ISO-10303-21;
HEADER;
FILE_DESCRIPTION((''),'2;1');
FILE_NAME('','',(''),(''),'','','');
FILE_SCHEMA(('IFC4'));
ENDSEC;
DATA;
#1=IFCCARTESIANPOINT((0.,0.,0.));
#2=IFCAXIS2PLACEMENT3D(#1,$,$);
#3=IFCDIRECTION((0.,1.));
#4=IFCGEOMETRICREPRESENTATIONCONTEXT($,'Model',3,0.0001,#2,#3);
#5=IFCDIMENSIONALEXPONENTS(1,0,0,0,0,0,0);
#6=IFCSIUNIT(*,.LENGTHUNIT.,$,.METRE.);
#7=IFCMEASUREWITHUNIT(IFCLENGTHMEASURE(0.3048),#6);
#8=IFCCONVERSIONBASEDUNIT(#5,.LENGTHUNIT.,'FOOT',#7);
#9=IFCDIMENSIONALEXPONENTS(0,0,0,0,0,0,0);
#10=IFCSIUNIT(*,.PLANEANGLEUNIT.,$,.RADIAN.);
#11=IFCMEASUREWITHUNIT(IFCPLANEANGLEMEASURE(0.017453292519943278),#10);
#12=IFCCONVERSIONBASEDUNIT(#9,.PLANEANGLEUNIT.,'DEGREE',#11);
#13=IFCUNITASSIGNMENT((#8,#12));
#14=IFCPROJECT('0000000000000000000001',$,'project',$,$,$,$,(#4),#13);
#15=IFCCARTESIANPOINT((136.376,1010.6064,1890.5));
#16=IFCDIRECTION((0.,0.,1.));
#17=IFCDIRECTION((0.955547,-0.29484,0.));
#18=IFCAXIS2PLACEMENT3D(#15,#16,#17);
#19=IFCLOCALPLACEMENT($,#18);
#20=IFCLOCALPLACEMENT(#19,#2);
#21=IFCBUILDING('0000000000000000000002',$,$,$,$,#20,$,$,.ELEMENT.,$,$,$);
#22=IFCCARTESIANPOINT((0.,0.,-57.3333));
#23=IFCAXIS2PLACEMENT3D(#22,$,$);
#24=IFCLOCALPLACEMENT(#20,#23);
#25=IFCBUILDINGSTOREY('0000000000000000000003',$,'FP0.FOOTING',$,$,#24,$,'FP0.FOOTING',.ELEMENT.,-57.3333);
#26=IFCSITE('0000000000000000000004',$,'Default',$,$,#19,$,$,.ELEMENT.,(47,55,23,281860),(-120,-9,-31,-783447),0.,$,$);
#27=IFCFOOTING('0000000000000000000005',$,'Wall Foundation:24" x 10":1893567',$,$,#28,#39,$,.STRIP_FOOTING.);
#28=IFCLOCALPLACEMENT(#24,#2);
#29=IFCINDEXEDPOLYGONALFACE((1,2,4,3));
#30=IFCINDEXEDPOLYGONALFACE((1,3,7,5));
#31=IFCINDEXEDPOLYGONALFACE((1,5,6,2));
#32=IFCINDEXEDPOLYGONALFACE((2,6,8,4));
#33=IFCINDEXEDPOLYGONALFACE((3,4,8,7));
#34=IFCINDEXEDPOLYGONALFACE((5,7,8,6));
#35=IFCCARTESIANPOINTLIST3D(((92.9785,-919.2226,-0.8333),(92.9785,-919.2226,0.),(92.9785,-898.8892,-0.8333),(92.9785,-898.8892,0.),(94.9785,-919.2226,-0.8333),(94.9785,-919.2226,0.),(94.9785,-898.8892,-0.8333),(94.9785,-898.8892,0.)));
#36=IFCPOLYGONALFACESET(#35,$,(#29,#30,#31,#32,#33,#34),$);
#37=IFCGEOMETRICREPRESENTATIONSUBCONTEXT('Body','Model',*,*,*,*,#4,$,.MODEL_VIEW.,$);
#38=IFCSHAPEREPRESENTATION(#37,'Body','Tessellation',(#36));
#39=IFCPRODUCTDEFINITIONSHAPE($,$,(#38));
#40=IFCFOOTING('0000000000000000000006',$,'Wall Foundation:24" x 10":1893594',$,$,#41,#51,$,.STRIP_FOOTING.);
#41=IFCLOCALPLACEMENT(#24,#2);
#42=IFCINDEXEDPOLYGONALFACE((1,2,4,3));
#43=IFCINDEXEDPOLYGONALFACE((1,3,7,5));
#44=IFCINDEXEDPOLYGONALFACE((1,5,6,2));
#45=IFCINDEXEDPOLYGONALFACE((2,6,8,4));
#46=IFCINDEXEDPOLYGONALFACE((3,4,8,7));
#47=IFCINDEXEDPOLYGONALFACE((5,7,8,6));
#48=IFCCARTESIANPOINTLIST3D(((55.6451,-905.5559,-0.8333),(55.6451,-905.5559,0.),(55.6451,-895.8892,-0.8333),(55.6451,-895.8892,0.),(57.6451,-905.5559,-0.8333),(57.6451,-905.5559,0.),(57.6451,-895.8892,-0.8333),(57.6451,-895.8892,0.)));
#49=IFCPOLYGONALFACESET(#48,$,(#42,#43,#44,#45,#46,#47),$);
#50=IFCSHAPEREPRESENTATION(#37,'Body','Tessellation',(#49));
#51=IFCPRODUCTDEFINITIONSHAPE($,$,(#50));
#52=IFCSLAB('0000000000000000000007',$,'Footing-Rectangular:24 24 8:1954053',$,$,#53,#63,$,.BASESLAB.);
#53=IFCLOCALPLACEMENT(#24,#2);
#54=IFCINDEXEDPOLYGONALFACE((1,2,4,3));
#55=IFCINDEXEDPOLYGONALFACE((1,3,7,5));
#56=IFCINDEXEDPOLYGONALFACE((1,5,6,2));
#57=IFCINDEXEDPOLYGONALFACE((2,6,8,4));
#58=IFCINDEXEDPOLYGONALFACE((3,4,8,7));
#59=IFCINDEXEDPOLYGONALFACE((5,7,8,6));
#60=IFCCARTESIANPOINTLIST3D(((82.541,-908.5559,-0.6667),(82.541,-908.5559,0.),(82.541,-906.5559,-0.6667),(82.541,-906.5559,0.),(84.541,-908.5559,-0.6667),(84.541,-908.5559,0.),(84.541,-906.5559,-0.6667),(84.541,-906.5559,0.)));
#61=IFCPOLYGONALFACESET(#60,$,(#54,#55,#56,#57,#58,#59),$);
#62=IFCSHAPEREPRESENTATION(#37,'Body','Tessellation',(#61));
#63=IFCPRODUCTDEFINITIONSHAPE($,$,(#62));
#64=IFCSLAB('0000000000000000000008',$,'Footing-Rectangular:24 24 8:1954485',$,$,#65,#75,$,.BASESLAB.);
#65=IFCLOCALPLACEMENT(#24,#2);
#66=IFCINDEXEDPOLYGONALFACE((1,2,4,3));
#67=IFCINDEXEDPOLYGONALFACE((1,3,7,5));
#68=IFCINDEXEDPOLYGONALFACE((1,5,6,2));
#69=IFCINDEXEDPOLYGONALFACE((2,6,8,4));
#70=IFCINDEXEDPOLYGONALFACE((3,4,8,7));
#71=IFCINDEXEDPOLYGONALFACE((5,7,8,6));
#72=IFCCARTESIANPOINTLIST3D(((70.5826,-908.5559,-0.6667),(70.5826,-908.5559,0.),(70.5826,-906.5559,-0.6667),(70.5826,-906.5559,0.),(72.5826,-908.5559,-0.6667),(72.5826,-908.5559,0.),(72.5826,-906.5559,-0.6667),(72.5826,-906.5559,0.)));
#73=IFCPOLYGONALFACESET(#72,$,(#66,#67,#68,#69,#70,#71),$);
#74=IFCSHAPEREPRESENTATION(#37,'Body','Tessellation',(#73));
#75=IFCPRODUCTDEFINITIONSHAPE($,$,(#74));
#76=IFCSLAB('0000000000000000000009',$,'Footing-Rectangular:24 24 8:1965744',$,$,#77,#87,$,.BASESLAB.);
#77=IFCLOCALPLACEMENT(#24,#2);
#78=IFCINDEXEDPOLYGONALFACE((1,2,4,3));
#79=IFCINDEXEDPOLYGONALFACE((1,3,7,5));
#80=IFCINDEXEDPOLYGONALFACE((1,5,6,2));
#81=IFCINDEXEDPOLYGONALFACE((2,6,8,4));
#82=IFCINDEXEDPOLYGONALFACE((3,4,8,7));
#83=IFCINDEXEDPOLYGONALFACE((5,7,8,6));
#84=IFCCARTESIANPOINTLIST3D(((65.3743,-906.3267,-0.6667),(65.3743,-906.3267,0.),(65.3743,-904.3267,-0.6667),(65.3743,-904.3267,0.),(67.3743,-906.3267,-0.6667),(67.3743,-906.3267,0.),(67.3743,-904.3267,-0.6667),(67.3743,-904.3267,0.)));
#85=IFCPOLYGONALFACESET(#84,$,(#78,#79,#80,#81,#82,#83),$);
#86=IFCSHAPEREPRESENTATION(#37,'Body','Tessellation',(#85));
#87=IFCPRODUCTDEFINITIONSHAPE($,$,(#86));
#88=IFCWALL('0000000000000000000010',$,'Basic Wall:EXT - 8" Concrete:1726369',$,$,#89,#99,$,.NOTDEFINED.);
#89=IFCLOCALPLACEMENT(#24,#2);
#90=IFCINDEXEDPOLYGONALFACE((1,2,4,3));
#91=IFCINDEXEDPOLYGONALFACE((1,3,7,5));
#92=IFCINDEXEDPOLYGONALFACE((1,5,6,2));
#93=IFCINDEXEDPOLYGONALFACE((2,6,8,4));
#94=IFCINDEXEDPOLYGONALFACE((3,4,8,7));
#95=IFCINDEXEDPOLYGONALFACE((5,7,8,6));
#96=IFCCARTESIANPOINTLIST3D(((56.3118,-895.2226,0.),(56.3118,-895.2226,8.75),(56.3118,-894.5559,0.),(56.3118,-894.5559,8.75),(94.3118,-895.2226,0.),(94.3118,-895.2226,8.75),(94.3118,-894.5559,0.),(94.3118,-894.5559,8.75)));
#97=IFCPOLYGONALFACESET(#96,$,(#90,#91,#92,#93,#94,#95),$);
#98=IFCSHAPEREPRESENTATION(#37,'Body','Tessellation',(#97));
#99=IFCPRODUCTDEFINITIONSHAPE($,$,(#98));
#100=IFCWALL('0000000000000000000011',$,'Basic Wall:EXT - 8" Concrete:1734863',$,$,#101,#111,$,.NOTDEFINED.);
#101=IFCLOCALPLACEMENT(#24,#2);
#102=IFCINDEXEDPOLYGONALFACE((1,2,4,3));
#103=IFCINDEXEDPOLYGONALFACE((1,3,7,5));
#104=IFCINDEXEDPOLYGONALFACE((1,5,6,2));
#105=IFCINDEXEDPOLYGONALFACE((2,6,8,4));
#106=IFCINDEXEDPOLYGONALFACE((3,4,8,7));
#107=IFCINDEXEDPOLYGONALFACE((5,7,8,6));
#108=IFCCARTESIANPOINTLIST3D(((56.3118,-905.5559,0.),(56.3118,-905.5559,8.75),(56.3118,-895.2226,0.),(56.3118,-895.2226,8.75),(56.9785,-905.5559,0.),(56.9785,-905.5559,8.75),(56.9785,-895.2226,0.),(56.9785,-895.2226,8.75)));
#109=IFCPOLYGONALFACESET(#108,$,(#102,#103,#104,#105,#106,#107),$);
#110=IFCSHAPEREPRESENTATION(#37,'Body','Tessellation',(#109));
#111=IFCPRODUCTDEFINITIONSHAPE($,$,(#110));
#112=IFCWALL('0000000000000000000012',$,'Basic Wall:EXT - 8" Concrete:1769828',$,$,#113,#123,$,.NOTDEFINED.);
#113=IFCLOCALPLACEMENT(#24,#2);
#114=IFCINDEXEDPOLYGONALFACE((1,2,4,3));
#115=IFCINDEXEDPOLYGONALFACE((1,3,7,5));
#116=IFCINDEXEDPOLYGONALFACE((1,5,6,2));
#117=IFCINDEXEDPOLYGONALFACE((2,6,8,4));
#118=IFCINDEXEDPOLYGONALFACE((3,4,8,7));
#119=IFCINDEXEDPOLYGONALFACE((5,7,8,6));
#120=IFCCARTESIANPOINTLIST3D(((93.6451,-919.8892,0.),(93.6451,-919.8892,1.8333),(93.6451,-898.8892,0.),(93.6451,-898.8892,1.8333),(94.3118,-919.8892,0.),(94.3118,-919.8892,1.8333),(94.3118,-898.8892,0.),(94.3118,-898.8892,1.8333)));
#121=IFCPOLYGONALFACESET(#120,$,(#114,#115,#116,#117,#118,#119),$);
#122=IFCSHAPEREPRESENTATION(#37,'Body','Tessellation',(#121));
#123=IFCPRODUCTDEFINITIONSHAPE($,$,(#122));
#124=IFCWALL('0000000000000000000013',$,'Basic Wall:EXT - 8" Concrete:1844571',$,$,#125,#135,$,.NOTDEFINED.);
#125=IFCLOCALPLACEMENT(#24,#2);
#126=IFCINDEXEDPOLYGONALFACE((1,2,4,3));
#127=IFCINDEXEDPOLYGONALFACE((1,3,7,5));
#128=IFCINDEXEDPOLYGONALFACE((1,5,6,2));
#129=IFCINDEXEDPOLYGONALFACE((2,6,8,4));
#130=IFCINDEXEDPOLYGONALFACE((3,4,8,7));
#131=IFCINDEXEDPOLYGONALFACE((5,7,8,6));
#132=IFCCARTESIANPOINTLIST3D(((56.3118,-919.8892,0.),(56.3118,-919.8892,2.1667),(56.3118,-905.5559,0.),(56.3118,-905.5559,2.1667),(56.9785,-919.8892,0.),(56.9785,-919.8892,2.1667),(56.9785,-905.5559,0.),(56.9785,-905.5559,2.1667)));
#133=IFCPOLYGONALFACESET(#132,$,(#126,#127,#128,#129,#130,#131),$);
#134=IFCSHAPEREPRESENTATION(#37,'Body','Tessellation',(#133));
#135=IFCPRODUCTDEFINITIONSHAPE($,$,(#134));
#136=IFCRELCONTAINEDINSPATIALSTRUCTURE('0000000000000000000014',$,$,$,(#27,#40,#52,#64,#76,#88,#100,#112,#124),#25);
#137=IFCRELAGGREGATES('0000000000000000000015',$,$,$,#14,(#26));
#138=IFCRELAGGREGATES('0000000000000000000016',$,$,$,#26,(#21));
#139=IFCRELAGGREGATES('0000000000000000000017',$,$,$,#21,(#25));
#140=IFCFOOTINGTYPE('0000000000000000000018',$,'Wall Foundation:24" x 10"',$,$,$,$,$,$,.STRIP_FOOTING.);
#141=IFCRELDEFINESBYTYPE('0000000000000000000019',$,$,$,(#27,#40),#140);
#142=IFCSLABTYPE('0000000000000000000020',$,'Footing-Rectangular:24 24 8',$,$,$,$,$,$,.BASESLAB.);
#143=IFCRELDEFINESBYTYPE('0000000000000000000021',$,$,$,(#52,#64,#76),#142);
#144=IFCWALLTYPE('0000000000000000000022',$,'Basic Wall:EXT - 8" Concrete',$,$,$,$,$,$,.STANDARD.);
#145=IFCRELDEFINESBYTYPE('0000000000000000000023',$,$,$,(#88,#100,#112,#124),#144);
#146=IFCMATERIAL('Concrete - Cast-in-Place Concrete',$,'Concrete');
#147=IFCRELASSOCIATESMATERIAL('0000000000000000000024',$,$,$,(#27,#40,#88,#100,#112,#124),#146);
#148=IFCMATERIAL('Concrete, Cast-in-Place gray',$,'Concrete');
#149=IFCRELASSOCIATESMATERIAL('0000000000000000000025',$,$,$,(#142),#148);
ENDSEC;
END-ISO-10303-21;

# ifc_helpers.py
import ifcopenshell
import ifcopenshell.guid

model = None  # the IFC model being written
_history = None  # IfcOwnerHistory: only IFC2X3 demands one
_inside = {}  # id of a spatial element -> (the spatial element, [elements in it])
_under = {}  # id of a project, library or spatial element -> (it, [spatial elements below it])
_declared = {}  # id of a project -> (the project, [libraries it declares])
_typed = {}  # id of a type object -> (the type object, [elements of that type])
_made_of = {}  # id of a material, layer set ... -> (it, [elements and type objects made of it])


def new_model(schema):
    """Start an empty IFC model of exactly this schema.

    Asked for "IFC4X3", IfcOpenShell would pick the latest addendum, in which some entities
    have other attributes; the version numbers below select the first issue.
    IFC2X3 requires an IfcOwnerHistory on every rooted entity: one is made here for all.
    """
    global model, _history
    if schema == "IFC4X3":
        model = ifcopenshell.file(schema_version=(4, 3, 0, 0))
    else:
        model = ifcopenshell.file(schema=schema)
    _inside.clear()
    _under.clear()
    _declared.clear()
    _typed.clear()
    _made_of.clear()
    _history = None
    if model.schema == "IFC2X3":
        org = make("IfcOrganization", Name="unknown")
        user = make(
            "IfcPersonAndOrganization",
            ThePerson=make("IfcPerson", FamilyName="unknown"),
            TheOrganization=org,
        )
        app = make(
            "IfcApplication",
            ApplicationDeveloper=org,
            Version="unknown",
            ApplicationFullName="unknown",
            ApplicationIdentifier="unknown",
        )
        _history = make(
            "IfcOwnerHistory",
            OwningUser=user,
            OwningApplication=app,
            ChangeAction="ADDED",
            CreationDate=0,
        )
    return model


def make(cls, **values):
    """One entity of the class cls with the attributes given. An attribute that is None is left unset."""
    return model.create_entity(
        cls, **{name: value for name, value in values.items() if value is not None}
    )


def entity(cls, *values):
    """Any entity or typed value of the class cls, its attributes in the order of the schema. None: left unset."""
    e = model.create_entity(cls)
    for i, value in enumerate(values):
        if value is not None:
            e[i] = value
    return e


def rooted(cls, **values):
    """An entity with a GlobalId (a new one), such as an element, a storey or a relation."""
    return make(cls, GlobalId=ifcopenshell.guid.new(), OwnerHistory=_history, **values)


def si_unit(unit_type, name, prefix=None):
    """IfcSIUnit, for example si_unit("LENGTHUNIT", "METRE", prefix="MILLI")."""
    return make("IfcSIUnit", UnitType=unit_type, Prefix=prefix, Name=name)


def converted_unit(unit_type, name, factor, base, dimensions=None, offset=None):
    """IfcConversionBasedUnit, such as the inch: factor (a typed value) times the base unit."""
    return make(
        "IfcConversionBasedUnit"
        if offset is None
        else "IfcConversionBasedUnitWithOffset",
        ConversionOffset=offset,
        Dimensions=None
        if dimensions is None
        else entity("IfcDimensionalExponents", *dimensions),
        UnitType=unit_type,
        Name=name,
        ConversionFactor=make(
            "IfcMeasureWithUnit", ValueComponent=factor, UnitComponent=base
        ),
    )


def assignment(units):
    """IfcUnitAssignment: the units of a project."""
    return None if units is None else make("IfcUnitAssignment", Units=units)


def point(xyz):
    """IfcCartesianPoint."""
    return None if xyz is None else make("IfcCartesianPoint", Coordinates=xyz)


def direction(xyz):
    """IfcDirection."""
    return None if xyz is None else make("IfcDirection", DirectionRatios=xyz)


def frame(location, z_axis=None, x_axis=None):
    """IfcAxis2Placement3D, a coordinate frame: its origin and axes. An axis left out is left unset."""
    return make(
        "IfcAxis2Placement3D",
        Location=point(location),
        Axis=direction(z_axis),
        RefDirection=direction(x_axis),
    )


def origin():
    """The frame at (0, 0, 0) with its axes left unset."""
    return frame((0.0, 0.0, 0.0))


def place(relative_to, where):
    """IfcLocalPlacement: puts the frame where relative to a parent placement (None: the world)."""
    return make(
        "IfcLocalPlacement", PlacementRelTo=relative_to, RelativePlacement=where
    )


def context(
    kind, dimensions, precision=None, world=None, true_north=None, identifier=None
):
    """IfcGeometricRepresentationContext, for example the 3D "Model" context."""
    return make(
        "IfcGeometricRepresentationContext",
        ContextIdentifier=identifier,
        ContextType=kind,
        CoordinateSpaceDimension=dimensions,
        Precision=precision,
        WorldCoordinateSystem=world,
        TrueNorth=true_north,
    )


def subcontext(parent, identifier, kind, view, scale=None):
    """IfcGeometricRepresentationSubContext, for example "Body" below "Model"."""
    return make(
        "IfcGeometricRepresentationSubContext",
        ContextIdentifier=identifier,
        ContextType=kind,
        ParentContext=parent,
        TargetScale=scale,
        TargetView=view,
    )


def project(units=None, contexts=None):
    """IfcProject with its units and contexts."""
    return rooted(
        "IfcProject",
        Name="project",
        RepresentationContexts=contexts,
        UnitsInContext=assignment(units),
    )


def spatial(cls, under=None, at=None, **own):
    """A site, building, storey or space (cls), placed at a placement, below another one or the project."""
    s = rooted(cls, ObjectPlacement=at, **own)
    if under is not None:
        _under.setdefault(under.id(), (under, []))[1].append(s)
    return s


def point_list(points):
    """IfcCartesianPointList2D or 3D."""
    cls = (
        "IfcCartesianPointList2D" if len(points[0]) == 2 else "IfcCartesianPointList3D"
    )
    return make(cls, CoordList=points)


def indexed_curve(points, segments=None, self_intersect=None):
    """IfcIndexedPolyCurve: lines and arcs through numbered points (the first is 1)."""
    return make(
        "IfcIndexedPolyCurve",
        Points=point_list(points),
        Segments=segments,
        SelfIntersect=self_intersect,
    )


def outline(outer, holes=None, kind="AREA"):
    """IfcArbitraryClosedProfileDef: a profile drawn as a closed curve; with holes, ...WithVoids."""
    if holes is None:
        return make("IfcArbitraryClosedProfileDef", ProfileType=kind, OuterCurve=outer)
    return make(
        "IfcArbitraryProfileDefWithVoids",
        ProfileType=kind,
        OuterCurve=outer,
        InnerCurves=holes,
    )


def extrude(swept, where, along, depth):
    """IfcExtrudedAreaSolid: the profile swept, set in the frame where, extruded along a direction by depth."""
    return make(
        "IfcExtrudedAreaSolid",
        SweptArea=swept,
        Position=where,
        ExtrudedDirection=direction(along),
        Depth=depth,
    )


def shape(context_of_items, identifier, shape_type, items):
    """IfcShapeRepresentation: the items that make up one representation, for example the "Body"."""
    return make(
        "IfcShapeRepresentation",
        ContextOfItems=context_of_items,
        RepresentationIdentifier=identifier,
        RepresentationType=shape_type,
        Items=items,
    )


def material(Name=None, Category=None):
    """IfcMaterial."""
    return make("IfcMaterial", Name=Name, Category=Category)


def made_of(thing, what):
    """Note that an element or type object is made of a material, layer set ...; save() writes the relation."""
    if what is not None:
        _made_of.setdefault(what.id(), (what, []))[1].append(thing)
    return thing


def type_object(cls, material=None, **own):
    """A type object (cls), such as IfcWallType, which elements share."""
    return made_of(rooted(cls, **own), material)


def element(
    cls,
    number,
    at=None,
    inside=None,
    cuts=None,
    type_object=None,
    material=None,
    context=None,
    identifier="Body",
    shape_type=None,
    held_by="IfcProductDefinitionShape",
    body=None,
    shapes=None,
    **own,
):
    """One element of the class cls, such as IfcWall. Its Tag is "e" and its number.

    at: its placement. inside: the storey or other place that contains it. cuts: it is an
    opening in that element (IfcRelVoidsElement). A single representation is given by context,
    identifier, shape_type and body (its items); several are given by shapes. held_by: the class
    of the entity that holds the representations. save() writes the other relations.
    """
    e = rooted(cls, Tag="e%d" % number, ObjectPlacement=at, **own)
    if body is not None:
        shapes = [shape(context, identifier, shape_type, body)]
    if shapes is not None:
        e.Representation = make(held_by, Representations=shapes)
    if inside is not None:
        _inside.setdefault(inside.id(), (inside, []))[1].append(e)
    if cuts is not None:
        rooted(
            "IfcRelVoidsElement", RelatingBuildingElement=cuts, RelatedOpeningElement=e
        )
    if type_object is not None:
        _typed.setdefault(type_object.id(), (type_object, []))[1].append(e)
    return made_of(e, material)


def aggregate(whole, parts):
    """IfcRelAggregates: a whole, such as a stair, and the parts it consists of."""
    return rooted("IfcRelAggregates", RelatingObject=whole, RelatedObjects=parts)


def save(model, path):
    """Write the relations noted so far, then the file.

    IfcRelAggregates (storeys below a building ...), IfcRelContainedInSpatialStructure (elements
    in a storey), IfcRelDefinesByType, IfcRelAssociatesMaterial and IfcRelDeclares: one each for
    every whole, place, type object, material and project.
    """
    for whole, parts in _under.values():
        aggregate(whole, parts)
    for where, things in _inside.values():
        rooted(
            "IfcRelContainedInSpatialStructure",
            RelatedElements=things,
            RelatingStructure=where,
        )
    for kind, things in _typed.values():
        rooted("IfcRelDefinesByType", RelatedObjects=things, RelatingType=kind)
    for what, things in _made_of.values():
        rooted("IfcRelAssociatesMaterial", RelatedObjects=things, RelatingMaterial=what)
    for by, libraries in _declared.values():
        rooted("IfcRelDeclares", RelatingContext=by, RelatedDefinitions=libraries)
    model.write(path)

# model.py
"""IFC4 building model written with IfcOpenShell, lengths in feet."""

from ifc_helpers import new_model, entity, si_unit, converted_unit, direction, frame, origin, place, context, subcontext, project, spatial, indexed_curve, outline, extrude, material, type_object, element, save


model = new_model("IFC4")

# Units and contexts
model_context = context("Model", 3, precision=0.0001, world=origin(), true_north=direction((0.0, 1.0)))
body_context = subcontext(model_context, "Body", "Model", "MODEL_VIEW")
ifc_project = project(units=[converted_unit("LENGTHUNIT", "FOOT", entity("IfcLengthMeasure", 0.3048), si_unit("LENGTHUNIT", "METRE"), dimensions=[1, 0, 0, 0, 0, 0, 0]), converted_unit("PLANEANGLEUNIT", "DEGREE", entity("IfcPlaneAngleMeasure", 0.017453292519943278), si_unit("PLANEANGLEUNIT", "RADIAN"), dimensions=[0, 0, 0, 0, 0, 0, 0])], contexts=[model_context])

# Site, building, storey
site_placement = place(None, frame((136.376, 1010.6064, 1890.5), z_axis=(0.0, 0.0, 1.0), x_axis=(0.955547, -0.29484, 0.0)))
site = spatial("IfcSite", under=ifc_project, at=site_placement, Name="Default", CompositionType="ELEMENT", RefLatitude=(47, 55, 23, 281860), RefLongitude=(-120, -9, -31, -783447), RefElevation=0.0)
building_placement = place(site_placement, origin())
building = spatial("IfcBuilding", under=site, at=building_placement, CompositionType="ELEMENT")
storey_placement = place(building_placement, frame((0.0, 0.0, -57.3333)))
storey = spatial("IfcBuildingStorey", under=building, at=storey_placement, Name="FP0.FOOTING", LongName="FP0.FOOTING", CompositionType="ELEMENT", Elevation=-57.3333)

# Footings
ifc_material_1 = material(Name="Concrete - Cast-in-Place Concrete", Category="Concrete")
footing_type = type_object("IfcFootingType", Name="Wall Foundation:24\" x 10\"", PredefinedType="STRIP_FOOTING")
footing_1_placement = place(storey_placement, origin())
element("IfcFooting", 1, at=footing_1_placement, inside=storey, type_object=footing_type, material=ifc_material_1, Name="Wall Foundation:24\" x 10\":1893567", PredefinedType="STRIP_FOOTING", context=body_context, shape_type="SweptSolid", body=[
    extrude(outline(indexed_curve([(-10.1667, -1.0), (10.1667, -1.0), (10.1667, 1.0), (-10.1667, 1.0), (-10.1667, -1.0)], self_intersect=False)), frame((93.9785, -909.0559, -0.8333), z_axis=(0.0, 0.0, 1.0), x_axis=(0.0, -1.0, 0.0)), (0.0, 0.0, 1.0), 0.8333),
])
footing_2_placement = place(storey_placement, origin())
element("IfcFooting", 2, at=footing_2_placement, inside=storey, type_object=footing_type, material=ifc_material_1, Name="Wall Foundation:24\" x 10\":1893594", PredefinedType="STRIP_FOOTING", context=body_context, shape_type="SweptSolid", body=[
    extrude(outline(indexed_curve([(-4.8333, -1.0), (4.8333, -1.0), (4.8333, 1.0), (-4.8333, 1.0), (-4.8333, -1.0)], self_intersect=False)), frame((56.6451, -900.7226, -0.8333), z_axis=(0.0, 0.0, 1.0), x_axis=(0.0, 1.0, 0.0)), (0.0, 0.0, 1.0), 0.8333),
])

# Slabs
ifc_material_2 = material(Name="Concrete, Cast-in-Place gray", Category="Concrete")
slab_type = type_object("IfcSlabType", Name="Footing-Rectangular:24 24 8", PredefinedType="BASESLAB", material=ifc_material_2)
slab_1_placement = place(storey_placement, origin())
element("IfcSlab", 3, at=slab_1_placement, inside=storey, type_object=slab_type, Name="Footing-Rectangular:24 24 8:1954053", PredefinedType="BASESLAB", context=body_context, shape_type="SweptSolid", body=[
    extrude(outline(indexed_curve([(-1.0, -1.0), (1.0, -1.0), (1.0, 1.0), (-1.0, 1.0), (-1.0, -1.0)], self_intersect=False)), frame((83.541, -907.5559, -0.6667), z_axis=(0.0, 0.0, 1.0), x_axis=(-1.0, 0.0, 0.0)), (0.0, 0.0, 1.0), 0.6667),
])
slab_2_placement = place(storey_placement, origin())
element("IfcSlab", 4, at=slab_2_placement, inside=storey, type_object=slab_type, Name="Footing-Rectangular:24 24 8:1954485", PredefinedType="BASESLAB", context=body_context, shape_type="SweptSolid", body=[
    extrude(outline(indexed_curve([(-1.0, -1.0), (1.0, -1.0), (1.0, 1.0), (-1.0, 1.0), (-1.0, -1.0)], self_intersect=False)), frame((71.5826, -907.5559, -0.6667), z_axis=(0.0, 0.0, 1.0), x_axis=(-1.0, 0.0, 0.0)), (0.0, 0.0, 1.0), 0.6667),
])
slab_3_placement = place(storey_placement, origin())
element("IfcSlab", 5, at=slab_3_placement, inside=storey, type_object=slab_type, Name="Footing-Rectangular:24 24 8:1965744", PredefinedType="BASESLAB", context=body_context, shape_type="SweptSolid", body=[
    extrude(outline(indexed_curve([(-1.0, -1.0), (1.0, -1.0), (1.0, 1.0), (-1.0, 1.0), (-1.0, -1.0)], self_intersect=False)), frame((66.3743, -905.3267, -0.6667), z_axis=(0.0, 0.0, 1.0), x_axis=(-1.0, 0.0, 0.0)), (0.0, 0.0, 1.0), 0.6667),
])

# Walls
wall_type = type_object("IfcWallType", Name="Basic Wall:EXT - 8\" Concrete", PredefinedType="STANDARD")
wall_1_placement = place(storey_placement, frame((94.3118, -894.8892, 0.0), z_axis=(0.0, 0.0, 1.0), x_axis=(-1.0, 0.0, 0.0)))
element("IfcWall", 6, at=wall_1_placement, inside=storey, type_object=wall_type, material=ifc_material_1, Name="Basic Wall:EXT - 8\" Concrete:1726369", PredefinedType="NOTDEFINED", context=body_context, shape_type="SweptSolid", body=[
    extrude(outline(indexed_curve([(38.0, 0.3333), (0.0, 0.3333), (0.0, -0.3333), (38.0, -0.3333), (38.0, 0.3333)], self_intersect=False)), origin(), (0.0, 0.0, 1.0), 8.75),
])
wall_2_placement = place(storey_placement, frame((56.6451, -905.5559, 0.0), z_axis=(0.0, 0.0, 1.0), x_axis=(0.0, 1.0, 0.0)))
element("IfcWall", 7, at=wall_2_placement, inside=storey, type_object=wall_type, material=ifc_material_1, Name="Basic Wall:EXT - 8\" Concrete:1734863", PredefinedType="NOTDEFINED", context=body_context, shape_type="SweptSolid", body=[
    extrude(outline(indexed_curve([(10.3333, 0.3333), (0.0, 0.3333), (0.0, -0.3333), (10.3333, -0.3333), (10.3333, 0.3333)], self_intersect=False)), origin(), (0.0, 0.0, 1.0), 8.75),
])
wall_3_placement = place(storey_placement, frame((93.9785, -898.8892, 0.0), z_axis=(0.0, 0.0, 1.0), x_axis=(0.0, -1.0, 0.0)))
element("IfcWall", 8, at=wall_3_placement, inside=storey, type_object=wall_type, material=ifc_material_1, Name="Basic Wall:EXT - 8\" Concrete:1769828", PredefinedType="NOTDEFINED", context=body_context, shape_type="SweptSolid", body=[
    extrude(outline(indexed_curve([(21.0, 0.3333), (0.0, 0.3333), (0.0, -0.3333), (21.0, -0.3333), (21.0, 0.3333)], self_intersect=False)), origin(), (0.0, 0.0, 1.0), 1.8333),
])
wall_4_placement = place(storey_placement, frame((56.6451, -905.5559, 0.0), z_axis=(0.0, 0.0, 1.0), x_axis=(0.0, -1.0, 0.0)))
element("IfcWall", 9, at=wall_4_placement, inside=storey, type_object=wall_type, material=ifc_material_1, Name="Basic Wall:EXT - 8\" Concrete:1844571", PredefinedType="NOTDEFINED", context=body_context, shape_type="SweptSolid", body=[
    extrude(outline(indexed_curve([(14.3333, 0.3333), (0.0, 0.3333), (0.0, -0.3333), (14.3333, -0.3333), (14.3333, 0.3333)], self_intersect=False)), origin(), (0.0, 0.0, 1.0), 2.1667),
])

save(model, "model.ifc")
